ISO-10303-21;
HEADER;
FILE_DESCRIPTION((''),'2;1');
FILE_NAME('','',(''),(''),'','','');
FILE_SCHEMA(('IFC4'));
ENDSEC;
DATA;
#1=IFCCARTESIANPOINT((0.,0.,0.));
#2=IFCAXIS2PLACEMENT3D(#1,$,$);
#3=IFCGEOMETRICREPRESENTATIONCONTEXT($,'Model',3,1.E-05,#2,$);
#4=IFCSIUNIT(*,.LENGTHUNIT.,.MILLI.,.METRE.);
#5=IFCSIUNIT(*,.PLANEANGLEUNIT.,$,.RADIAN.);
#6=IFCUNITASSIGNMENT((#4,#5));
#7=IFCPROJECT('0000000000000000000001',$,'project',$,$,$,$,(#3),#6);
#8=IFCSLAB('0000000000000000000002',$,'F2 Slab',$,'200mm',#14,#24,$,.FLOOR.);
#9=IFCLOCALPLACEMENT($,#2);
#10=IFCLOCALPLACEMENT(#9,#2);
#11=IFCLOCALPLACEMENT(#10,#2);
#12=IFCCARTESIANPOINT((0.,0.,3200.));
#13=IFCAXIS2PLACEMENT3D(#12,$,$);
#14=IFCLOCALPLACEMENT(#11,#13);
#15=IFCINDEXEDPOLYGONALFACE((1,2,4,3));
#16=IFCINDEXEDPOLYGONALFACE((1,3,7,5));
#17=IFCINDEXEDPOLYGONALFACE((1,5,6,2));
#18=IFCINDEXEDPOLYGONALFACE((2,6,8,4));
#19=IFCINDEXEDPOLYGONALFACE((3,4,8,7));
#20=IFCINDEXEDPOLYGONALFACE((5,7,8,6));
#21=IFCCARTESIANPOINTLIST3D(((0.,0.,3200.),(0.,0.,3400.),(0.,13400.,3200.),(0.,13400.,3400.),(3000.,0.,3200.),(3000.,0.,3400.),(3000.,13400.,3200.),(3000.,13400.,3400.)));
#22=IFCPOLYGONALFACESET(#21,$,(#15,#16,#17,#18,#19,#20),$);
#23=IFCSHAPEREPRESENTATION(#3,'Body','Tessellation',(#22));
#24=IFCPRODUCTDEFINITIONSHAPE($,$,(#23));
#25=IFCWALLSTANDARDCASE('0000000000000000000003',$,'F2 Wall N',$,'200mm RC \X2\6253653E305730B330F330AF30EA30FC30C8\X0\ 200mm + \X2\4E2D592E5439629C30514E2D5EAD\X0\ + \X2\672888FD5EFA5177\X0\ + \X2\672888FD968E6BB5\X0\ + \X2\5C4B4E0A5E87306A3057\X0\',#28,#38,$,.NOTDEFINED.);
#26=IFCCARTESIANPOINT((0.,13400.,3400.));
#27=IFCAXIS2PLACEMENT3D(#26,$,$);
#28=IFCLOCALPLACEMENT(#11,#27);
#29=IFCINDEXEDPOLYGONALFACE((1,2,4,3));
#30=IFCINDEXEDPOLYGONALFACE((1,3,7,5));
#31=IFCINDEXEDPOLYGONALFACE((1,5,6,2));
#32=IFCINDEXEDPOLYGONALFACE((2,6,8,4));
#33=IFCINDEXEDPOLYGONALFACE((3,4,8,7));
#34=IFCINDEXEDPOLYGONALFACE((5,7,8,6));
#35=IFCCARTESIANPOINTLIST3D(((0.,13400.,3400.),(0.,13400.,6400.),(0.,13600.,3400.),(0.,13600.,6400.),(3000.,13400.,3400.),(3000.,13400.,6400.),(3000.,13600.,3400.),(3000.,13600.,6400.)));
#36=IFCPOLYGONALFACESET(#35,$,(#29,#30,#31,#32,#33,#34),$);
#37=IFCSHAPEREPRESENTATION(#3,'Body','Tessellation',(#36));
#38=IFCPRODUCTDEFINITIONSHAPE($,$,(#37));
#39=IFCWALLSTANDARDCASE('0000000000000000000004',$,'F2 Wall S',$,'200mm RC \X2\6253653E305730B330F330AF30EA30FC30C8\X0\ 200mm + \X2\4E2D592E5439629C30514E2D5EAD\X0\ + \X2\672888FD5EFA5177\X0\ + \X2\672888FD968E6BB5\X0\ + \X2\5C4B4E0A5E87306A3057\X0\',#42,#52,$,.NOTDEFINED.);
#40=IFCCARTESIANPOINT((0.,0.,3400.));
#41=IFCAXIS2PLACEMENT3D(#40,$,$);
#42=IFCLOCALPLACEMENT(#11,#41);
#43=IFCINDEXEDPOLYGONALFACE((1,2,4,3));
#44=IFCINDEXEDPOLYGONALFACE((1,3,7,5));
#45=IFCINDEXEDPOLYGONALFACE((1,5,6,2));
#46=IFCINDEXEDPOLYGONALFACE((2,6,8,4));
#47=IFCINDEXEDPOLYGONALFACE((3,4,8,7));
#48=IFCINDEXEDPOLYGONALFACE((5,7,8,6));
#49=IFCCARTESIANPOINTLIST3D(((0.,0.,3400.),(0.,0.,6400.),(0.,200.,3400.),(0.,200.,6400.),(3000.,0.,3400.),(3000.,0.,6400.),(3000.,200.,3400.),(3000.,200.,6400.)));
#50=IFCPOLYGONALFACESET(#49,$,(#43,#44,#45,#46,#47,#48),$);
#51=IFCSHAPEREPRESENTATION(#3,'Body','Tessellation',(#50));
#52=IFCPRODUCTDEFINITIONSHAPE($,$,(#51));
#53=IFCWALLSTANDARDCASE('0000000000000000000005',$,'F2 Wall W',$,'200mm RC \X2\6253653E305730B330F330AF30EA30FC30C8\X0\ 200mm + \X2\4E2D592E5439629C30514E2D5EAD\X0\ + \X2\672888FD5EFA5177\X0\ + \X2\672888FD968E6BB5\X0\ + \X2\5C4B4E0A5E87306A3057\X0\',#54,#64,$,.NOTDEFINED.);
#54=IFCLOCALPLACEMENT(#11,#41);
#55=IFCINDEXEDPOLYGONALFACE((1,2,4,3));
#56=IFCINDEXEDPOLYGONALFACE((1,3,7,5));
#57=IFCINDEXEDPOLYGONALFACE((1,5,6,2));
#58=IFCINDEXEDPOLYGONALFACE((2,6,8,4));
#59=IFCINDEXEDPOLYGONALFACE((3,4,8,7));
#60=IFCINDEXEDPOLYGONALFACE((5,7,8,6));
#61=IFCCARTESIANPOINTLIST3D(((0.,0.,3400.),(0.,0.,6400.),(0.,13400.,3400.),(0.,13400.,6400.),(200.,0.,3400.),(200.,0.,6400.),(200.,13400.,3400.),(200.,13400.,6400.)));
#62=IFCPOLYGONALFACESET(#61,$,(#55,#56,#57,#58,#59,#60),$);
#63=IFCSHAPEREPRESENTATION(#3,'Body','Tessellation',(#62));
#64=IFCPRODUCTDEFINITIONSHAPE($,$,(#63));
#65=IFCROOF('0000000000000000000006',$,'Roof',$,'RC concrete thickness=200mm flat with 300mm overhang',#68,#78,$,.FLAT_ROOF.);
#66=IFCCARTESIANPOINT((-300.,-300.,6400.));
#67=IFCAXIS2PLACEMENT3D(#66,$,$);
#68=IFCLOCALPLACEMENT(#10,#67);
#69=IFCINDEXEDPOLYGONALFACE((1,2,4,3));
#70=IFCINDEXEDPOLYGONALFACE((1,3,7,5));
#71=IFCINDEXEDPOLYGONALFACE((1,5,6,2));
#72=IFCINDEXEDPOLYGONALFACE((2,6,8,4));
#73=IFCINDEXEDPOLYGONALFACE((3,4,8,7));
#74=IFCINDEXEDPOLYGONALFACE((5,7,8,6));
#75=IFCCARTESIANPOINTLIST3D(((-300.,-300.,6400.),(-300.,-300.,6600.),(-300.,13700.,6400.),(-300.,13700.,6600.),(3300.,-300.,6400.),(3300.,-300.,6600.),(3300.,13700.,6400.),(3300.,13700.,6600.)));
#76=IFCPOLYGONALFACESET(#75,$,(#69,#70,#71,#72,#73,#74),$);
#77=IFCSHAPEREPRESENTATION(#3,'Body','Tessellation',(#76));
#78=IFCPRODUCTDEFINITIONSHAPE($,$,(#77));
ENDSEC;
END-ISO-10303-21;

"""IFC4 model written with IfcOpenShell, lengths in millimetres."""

from ifc_helpers import new_model, si_unit, frame, frame_2d, origin, place, context, project, rectangle, extrude, element, save


model = new_model("IFC4")

# Units and contexts
model_context = context("Model", 3, precision=1e-05, world=origin())
ifc_project = project(units=[si_unit("LENGTHUNIT", "METRE", prefix="MILLI"), si_unit("PLANEANGLEUNIT", "RADIAN")], contexts=[model_context])

# Slab
placement_1 = place(None, origin())
placement_2 = place(placement_1, origin())
placement_3 = place(placement_2, origin())
slab_placement = place(placement_3, frame((0.0, 0.0, 3200.0)))
element("IfcSlab", 1, at=slab_placement, Name="F2 Slab", ObjectType="200mm", PredefinedType="FLOOR", context=model_context, shape_type="SweptSolid", body=[
    extrude(rectangle(XDim=3000.0, YDim=13400.0, at=frame_2d((1500.0, 6700.0))), frame((0.0, 0.0, 3200.0)), (0.0, 0.0, 1.0), 200.0),
])

# Walls
wall_1_placement = place(placement_3, frame((0.0, 13400.0, 3400.0)))
element("IfcWallStandardCase", 2, at=wall_1_placement, Name="F2 Wall N", ObjectType="200mm RC 打放しコンクリート 200mm + 中央吹抜け中庭 + 木製建具 + 木製階段 + 屋上庇なし", PredefinedType="NOTDEFINED", context=model_context, shape_type="SweptSolid", body=[
    extrude(rectangle(XDim=3000.0, YDim=200.0, at=frame_2d((1500.0, 100.0))), frame((0.0, 13400.0, 3400.0)), (0.0, 0.0, 1.0), 3000.0),
])
wall_2_placement = place(placement_3, frame((0.0, 0.0, 3400.0)))
element("IfcWallStandardCase", 3, at=wall_2_placement, Name="F2 Wall S", ObjectType="200mm RC 打放しコンクリート 200mm + 中央吹抜け中庭 + 木製建具 + 木製階段 + 屋上庇なし", PredefinedType="NOTDEFINED", context=model_context, shape_type="SweptSolid", body=[
    extrude(rectangle(XDim=3000.0, YDim=200.0, at=frame_2d((1500.0, 100.0))), frame((0.0, 0.0, 3400.0)), (0.0, 0.0, 1.0), 3000.0),
])
wall_3_placement = place(placement_3, frame((0.0, 0.0, 3400.0)))
element("IfcWallStandardCase", 4, at=wall_3_placement, Name="F2 Wall W", ObjectType="200mm RC 打放しコンクリート 200mm + 中央吹抜け中庭 + 木製建具 + 木製階段 + 屋上庇なし", PredefinedType="NOTDEFINED", context=model_context, shape_type="SweptSolid", body=[
    extrude(rectangle(XDim=200.0, YDim=13400.0, at=frame_2d((100.0, 6700.0))), frame((0.0, 0.0, 3400.0)), (0.0, 0.0, 1.0), 3000.0),
])

# Roof
roof_placement = place(placement_2, frame((-300.0, -300.0, 6400.0)))
element("IfcRoof", 5, at=roof_placement, Name="Roof", ObjectType="RC concrete thickness=200mm flat with 300mm overhang", PredefinedType="FLAT_ROOF", context=model_context, shape_type="SweptSolid", body=[
    extrude(rectangle(XDim=3600.0, YDim=14000.0, at=frame_2d((1800.0, 7000.0))), frame((-300.0, -300.0, 6400.0)), (0.0, 0.0, 1.0), 200.0),
])

save(model, "model.ifc")
